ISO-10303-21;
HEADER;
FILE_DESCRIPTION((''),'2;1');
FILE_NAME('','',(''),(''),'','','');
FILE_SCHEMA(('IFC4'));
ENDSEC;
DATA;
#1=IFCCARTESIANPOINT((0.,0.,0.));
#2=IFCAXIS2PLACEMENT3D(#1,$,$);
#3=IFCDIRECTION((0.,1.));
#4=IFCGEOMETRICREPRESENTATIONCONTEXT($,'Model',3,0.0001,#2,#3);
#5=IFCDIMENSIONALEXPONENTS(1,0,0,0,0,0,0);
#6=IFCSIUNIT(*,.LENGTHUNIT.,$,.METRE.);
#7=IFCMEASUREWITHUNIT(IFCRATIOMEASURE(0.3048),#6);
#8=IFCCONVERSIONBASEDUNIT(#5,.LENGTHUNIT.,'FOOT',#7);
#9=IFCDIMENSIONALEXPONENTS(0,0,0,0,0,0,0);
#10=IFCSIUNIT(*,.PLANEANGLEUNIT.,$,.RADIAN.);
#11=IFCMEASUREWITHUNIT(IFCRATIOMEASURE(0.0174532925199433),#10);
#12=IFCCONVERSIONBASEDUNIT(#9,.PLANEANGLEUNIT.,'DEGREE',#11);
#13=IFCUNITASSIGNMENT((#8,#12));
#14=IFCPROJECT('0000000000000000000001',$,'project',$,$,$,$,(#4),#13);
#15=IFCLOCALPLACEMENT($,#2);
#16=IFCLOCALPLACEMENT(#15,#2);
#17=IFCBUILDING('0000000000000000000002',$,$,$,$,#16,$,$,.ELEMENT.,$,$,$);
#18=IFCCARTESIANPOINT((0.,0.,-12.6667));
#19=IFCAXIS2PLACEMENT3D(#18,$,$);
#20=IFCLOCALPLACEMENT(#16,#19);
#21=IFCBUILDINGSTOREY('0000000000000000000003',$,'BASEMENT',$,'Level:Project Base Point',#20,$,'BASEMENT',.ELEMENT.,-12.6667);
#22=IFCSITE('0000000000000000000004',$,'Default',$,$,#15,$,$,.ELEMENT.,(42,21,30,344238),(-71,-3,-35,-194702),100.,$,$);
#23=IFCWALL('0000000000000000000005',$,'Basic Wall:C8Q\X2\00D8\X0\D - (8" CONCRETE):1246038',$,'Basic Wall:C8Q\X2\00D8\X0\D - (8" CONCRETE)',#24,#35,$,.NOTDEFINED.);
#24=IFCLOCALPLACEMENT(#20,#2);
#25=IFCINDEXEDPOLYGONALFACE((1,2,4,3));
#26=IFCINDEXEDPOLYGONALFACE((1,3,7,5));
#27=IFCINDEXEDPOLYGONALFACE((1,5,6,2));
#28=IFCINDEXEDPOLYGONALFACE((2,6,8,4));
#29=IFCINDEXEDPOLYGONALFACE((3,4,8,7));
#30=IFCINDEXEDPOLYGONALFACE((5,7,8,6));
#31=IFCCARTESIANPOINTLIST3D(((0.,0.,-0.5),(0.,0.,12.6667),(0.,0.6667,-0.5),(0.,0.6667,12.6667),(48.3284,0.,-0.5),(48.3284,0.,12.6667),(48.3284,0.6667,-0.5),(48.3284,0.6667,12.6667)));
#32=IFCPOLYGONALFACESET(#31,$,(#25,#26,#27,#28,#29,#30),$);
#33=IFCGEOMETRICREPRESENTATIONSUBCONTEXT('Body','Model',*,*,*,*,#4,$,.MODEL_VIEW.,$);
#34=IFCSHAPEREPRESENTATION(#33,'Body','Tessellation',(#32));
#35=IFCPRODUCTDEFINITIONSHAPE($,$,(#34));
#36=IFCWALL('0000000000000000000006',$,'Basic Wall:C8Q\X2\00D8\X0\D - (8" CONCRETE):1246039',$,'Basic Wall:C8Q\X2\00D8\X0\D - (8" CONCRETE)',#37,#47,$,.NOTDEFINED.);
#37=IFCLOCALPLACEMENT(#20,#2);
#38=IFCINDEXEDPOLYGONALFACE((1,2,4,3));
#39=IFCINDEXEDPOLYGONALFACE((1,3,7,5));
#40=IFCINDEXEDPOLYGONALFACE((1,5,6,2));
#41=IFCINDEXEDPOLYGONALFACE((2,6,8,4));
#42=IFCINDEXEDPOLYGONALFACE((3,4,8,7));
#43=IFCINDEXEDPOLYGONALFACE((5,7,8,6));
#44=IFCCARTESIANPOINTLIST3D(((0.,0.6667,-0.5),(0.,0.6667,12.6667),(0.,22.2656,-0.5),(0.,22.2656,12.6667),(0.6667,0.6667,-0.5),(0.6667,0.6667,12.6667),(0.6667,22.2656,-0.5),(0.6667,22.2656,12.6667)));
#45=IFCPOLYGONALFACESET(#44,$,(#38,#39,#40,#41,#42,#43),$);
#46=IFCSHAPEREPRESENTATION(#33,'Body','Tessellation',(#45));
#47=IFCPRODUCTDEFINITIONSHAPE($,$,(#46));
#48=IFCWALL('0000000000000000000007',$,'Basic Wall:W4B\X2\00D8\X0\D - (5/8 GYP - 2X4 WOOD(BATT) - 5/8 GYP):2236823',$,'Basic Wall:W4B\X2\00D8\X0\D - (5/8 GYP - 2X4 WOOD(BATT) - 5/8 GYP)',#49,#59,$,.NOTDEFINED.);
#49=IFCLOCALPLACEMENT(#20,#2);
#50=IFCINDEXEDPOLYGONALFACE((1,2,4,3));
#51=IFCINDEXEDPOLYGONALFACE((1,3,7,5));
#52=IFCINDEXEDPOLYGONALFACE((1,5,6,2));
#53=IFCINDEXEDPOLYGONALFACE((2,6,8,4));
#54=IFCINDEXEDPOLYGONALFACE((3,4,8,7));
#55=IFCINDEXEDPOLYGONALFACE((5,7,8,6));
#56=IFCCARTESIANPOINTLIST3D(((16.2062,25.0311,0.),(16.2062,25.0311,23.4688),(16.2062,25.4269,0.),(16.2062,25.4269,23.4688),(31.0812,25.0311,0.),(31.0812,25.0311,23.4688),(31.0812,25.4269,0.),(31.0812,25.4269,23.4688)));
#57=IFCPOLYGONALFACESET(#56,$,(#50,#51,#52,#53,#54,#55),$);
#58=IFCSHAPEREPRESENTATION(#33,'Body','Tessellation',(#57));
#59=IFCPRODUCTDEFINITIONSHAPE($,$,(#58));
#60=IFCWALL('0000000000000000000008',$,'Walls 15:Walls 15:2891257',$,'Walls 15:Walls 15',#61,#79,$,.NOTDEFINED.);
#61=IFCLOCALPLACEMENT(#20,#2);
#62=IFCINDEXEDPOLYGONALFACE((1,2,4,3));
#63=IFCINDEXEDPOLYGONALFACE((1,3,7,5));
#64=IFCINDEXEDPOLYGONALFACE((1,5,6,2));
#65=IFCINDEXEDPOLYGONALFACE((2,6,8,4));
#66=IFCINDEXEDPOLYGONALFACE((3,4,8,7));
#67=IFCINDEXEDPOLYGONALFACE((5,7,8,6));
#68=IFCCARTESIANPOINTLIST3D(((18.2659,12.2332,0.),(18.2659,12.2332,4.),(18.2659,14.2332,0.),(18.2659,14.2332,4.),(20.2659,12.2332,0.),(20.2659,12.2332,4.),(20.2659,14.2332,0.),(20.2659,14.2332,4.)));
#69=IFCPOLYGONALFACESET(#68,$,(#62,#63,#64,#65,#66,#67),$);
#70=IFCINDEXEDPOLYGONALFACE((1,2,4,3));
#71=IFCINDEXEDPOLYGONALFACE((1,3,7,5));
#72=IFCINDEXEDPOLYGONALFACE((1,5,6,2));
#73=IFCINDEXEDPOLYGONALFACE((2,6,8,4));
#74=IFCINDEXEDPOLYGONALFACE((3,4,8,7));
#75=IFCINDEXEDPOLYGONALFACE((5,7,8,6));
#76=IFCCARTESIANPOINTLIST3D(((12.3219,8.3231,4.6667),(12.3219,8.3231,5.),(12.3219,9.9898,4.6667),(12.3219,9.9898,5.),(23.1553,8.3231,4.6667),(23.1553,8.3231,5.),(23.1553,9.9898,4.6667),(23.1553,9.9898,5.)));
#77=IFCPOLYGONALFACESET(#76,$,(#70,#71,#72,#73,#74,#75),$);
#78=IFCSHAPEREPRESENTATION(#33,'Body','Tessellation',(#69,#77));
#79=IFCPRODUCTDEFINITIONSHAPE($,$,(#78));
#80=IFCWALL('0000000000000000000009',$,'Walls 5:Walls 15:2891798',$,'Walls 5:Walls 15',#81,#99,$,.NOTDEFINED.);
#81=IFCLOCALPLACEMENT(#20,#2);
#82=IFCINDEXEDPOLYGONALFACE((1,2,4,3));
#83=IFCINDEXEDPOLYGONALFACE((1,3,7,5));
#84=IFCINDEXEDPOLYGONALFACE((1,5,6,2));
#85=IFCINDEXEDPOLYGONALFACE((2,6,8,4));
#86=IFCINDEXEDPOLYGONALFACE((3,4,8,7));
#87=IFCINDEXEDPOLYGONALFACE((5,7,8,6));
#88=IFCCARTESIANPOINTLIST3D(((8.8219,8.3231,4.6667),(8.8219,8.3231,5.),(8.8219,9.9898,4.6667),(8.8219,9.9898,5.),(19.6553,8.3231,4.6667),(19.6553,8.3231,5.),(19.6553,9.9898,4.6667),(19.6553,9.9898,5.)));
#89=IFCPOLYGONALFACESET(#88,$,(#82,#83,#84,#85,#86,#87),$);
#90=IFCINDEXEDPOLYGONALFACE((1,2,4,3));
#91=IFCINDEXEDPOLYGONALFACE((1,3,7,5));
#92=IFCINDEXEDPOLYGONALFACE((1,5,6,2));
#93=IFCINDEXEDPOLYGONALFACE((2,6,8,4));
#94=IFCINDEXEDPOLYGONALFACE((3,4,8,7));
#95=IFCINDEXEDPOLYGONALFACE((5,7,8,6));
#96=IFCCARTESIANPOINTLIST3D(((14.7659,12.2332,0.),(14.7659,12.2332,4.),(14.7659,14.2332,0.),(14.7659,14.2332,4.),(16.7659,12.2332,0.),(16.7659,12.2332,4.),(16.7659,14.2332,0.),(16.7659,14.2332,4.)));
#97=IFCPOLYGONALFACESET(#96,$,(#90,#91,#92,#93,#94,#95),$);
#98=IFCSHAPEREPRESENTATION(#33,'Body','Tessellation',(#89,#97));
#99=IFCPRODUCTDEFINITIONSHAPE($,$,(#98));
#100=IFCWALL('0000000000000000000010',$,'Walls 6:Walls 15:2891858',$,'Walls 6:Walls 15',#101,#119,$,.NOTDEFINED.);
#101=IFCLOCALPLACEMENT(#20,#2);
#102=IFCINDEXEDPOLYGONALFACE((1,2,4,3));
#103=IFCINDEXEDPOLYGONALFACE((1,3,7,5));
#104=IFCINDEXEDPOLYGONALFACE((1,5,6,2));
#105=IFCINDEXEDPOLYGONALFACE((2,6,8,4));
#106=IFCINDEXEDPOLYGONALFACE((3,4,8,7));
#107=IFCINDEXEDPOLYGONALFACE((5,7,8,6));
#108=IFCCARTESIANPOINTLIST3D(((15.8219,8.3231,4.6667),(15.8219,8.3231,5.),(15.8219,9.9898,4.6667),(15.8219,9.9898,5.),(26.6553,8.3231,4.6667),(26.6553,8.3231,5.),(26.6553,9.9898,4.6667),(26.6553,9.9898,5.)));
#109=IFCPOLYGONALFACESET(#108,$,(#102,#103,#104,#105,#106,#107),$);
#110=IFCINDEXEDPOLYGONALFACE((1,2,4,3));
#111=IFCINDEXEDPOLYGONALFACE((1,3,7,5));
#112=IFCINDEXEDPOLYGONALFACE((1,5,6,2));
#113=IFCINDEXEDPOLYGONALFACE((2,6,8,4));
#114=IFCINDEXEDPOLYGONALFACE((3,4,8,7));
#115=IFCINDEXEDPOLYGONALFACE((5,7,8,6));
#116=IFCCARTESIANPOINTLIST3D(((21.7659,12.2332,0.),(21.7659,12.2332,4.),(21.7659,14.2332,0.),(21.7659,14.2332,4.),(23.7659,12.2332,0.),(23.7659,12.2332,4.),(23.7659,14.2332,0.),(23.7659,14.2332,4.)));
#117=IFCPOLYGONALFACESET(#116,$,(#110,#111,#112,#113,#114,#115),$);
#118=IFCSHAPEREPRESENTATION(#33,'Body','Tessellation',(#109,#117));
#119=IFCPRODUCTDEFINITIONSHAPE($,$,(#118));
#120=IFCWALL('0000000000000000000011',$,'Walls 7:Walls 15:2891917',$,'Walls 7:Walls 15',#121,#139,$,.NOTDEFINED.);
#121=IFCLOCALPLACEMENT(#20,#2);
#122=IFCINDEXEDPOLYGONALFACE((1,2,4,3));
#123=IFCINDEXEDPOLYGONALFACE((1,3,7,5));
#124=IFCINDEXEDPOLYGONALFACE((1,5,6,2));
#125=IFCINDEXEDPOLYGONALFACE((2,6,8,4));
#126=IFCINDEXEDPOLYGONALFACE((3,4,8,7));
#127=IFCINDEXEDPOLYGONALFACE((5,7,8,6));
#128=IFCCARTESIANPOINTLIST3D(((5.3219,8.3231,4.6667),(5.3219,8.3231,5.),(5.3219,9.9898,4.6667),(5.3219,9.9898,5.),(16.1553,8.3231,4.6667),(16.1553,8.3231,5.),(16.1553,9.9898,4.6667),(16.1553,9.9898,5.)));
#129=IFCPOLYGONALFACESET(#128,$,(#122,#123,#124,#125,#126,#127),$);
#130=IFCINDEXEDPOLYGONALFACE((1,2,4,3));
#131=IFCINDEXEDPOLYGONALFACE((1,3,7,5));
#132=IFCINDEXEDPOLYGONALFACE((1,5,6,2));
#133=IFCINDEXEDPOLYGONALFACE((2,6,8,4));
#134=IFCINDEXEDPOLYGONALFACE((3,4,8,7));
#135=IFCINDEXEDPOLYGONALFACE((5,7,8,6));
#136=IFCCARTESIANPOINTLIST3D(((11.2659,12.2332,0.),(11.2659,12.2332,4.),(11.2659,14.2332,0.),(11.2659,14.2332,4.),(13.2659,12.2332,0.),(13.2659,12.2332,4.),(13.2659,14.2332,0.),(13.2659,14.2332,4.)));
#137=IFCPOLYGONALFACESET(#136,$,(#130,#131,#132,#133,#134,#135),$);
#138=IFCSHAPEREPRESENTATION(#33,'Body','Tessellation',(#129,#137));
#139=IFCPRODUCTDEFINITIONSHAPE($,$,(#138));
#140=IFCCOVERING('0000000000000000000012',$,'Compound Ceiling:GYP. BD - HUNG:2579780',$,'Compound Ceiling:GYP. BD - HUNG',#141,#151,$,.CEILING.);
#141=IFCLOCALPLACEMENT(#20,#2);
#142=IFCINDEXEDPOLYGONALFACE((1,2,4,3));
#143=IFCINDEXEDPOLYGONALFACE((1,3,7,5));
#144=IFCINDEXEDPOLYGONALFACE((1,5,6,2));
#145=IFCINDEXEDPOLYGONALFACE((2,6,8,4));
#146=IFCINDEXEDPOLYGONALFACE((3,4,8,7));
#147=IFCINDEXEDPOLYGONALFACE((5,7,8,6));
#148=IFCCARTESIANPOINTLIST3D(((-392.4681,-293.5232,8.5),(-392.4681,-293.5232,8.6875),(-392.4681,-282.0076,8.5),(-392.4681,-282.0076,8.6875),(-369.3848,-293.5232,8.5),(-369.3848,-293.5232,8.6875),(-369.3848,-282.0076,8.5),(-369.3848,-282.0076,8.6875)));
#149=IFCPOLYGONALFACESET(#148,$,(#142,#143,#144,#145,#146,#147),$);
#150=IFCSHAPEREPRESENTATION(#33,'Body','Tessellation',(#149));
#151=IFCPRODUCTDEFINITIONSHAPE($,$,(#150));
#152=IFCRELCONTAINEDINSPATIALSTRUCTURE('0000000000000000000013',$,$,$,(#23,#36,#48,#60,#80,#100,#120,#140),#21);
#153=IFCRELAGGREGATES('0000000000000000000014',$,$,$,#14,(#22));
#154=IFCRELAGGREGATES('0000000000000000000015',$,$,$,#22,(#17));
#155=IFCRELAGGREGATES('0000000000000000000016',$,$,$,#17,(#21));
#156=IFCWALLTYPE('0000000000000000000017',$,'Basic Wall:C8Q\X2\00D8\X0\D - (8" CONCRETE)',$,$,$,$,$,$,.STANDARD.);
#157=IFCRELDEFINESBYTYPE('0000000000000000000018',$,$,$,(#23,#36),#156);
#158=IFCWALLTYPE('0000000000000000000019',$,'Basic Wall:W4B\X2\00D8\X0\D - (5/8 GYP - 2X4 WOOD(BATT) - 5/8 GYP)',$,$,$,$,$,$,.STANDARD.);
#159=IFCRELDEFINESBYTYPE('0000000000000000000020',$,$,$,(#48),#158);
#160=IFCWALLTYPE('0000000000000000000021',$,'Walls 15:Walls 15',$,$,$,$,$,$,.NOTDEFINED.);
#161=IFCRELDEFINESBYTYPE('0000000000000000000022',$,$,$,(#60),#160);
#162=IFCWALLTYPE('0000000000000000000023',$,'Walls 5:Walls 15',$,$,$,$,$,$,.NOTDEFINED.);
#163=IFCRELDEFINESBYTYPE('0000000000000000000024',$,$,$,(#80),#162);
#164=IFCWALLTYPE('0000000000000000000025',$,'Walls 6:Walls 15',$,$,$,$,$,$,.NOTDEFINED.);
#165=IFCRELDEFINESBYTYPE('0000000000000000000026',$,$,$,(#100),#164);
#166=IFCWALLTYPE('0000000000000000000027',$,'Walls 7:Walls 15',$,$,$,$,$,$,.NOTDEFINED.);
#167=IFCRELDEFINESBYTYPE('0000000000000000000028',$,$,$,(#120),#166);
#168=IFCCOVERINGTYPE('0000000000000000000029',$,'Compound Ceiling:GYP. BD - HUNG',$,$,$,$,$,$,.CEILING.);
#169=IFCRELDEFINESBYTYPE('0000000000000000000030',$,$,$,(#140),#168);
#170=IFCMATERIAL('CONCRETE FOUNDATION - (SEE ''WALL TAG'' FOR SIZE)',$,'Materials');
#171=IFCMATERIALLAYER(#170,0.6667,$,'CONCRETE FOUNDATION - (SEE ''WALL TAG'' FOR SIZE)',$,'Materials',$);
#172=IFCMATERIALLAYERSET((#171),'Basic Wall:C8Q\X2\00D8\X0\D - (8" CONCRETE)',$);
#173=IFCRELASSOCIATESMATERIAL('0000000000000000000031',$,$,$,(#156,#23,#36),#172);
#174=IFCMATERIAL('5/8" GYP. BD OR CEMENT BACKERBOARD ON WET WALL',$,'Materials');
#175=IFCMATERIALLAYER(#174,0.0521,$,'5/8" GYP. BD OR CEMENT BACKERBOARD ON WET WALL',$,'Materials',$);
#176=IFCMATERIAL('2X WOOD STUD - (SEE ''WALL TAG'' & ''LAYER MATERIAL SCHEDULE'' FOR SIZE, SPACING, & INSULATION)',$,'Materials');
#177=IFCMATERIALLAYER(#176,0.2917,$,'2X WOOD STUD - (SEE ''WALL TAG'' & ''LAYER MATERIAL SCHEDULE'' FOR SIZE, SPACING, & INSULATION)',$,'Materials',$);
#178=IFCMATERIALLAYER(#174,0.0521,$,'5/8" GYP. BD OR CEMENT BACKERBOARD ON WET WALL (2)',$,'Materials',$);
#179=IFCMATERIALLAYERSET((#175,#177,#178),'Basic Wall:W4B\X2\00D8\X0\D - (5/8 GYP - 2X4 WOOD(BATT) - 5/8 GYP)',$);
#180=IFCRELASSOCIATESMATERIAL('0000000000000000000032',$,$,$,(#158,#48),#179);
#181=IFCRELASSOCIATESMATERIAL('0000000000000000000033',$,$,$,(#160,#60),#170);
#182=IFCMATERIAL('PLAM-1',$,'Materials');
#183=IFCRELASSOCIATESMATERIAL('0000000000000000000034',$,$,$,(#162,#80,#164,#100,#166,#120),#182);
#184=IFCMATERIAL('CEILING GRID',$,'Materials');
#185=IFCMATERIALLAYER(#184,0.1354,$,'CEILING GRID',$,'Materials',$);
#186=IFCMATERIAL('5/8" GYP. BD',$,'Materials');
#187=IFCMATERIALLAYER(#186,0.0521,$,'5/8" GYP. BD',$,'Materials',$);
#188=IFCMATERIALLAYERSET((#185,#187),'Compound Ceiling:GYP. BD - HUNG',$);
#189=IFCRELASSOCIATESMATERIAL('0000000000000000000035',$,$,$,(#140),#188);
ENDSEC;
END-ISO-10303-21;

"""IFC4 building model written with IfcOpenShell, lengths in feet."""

from ifc_helpers import new_model, entity, si_unit, converted_unit, direction, frame, frame_2d, origin, origin_2d_with_axis, place, context, subcontext, project, spatial, rectangle, extrude, material, layer, layer_set, layer_usage, type_object, element, save


model = new_model("IFC4")

# Units and contexts
model_context = context("Model", 3, precision=0.0001, world=origin(), true_north=direction((0.0, 1.0)))
body_context = subcontext(model_context, "Body", "Model", "MODEL_VIEW")
ifc_project = project(units=[converted_unit("LENGTHUNIT", "FOOT", entity("IfcRatioMeasure", 0.3048), si_unit("LENGTHUNIT", "METRE"), dimensions=[1, 0, 0, 0, 0, 0, 0]), converted_unit("PLANEANGLEUNIT", "DEGREE", entity("IfcRatioMeasure", 0.0174532925199433), si_unit("PLANEANGLEUNIT", "RADIAN"), dimensions=[0, 0, 0, 0, 0, 0, 0])], contexts=[model_context])

# Site, building, storey
site_placement = place(None, origin())
site = spatial("IfcSite", under=ifc_project, at=site_placement, Name="Default", CompositionType="ELEMENT", RefLatitude=(42, 21, 30, 344238), RefLongitude=(-71, -3, -35, -194702), RefElevation=100.0)
building_placement = place(site_placement, origin())
building = spatial("IfcBuilding", under=site, at=building_placement, CompositionType="ELEMENT")
storey_placement = place(building_placement, frame((0.0, 0.0, -12.6667)))
storey = spatial("IfcBuildingStorey", under=building, at=storey_placement, Name="BASEMENT", ObjectType="Level:Project Base Point", LongName="BASEMENT", CompositionType="ELEMENT", Elevation=-12.6667)

# Shared definitions
ifc_material_1 = material(Name="5/8\" GYP. BD", Category="Materials")

# Walls
ifc_material_2 = material(Name="CONCRETE FOUNDATION - (SEE 'WALL TAG' FOR SIZE)", Category="Materials")
ifc_layer_1 = layer(ifc_material_2, 0.6667, Name="CONCRETE FOUNDATION - (SEE 'WALL TAG' FOR SIZE)", Category="Materials")
ifc_layer_set_1 = layer_set([ifc_layer_1], Name="Basic Wall:C8QØD - (8\" CONCRETE)")
ifc_layer_usage_1 = layer_usage(ifc_layer_set_1, "AXIS2", "POSITIVE", -0.3333)
wall_type_1 = type_object("IfcWallType", Name="Basic Wall:C8QØD - (8\" CONCRETE)", PredefinedType="STANDARD", material=ifc_layer_set_1)
wall_1_placement = place(storey_placement, frame((0.0, 0.3333, -0.5)))
element("IfcWall", 1, at=wall_1_placement, inside=storey, type_object=wall_type_1, material=ifc_layer_usage_1, Name="Basic Wall:C8QØD - (8\" CONCRETE):1246038", ObjectType="Basic Wall:C8QØD - (8\" CONCRETE)", PredefinedType="NOTDEFINED", context=body_context, shape_type="SweptSolid", body=[
    extrude(rectangle(XDim=48.3284, YDim=0.6667, at=frame_2d((24.1642, 0.0), x_axis=(-1.0, 0.0))), origin(), (0.0, 0.0, 1.0), 13.1667),
])
ifc_layer_usage_2 = layer_usage(ifc_layer_set_1, "AXIS2", "POSITIVE", -0.3333)
wall_2_placement = place(storey_placement, frame((0.3333, 22.2656, -0.5), z_axis=(0.0, 0.0, 1.0), x_axis=(0.0, -1.0, 0.0)))
element("IfcWall", 2, at=wall_2_placement, inside=storey, type_object=wall_type_1, material=ifc_layer_usage_2, Name="Basic Wall:C8QØD - (8\" CONCRETE):1246039", ObjectType="Basic Wall:C8QØD - (8\" CONCRETE)", PredefinedType="NOTDEFINED", context=body_context, shape_type="SweptSolid", body=[
    extrude(rectangle(XDim=21.599, YDim=0.6667, at=frame_2d((10.7995, 0.0), x_axis=(-1.0, 0.0))), origin(), (0.0, 0.0, 1.0), 13.1667),
])
ifc_material_3 = material(Name="5/8\" GYP. BD OR CEMENT BACKERBOARD ON WET WALL", Category="Materials")
ifc_layer_2 = layer(ifc_material_3, 0.0521, Name="5/8\" GYP. BD OR CEMENT BACKERBOARD ON WET WALL", Category="Materials")
ifc_material_4 = material(Name="2X WOOD STUD - (SEE 'WALL TAG' & 'LAYER MATERIAL SCHEDULE' FOR SIZE, SPACING, & INSULATION)", Category="Materials")
ifc_layer_3 = layer(ifc_material_4, 0.2917, Name="2X WOOD STUD - (SEE 'WALL TAG' & 'LAYER MATERIAL SCHEDULE' FOR SIZE, SPACING, & INSULATION)", Category="Materials")
ifc_layer_4 = layer(ifc_material_3, 0.0521, Name="5/8\" GYP. BD OR CEMENT BACKERBOARD ON WET WALL (2)", Category="Materials")
ifc_layer_set_2 = layer_set([ifc_layer_2, ifc_layer_3, ifc_layer_4], Name="Basic Wall:W4BØD - (5/8 GYP - 2X4 WOOD(BATT) - 5/8 GYP)")
ifc_layer_usage_3 = layer_usage(ifc_layer_set_2, "AXIS2", "NEGATIVE", 0.1979)
wall_type_2 = type_object("IfcWallType", Name="Basic Wall:W4BØD - (5/8 GYP - 2X4 WOOD(BATT) - 5/8 GYP)", PredefinedType="STANDARD", material=ifc_layer_set_2)
wall_3_placement = place(storey_placement, frame((16.2062, 25.229, 0.0)))
element("IfcWall", 3, at=wall_3_placement, inside=storey, type_object=wall_type_2, material=ifc_layer_usage_3, Name="Basic Wall:W4BØD - (5/8 GYP - 2X4 WOOD(BATT) - 5/8 GYP):2236823", ObjectType="Basic Wall:W4BØD - (5/8 GYP - 2X4 WOOD(BATT) - 5/8 GYP)", PredefinedType="NOTDEFINED", context=body_context, shape_type="SweptSolid", body=[
    extrude(rectangle(XDim=14.875, YDim=0.3958, at=frame_2d((7.4375, 0.0), x_axis=(-1.0, 0.0))), origin(), (0.0, 0.0, 1.0), 23.4688),
])
wall_type_3 = type_object("IfcWallType", Name="Walls 15:Walls 15", PredefinedType="NOTDEFINED", material=ifc_material_2)
wall_4_placement = place(storey_placement, frame((12.3219, 8.3231, 0.0)))
element("IfcWall", 4, at=wall_4_placement, inside=storey, type_object=wall_type_3, material=ifc_material_2, Name="Walls 15:Walls 15:2891257", ObjectType="Walls 15:Walls 15", PredefinedType="NOTDEFINED", context=body_context, shape_type="SweptSolid", body=[
    extrude(rectangle(XDim=2.0, YDim=2.0, at=origin_2d_with_axis()), frame((6.944, 4.9101, 0.0), z_axis=(0.0, 0.0, 1.0), x_axis=(-1.0, 0.0, 0.0)), (0.0, 0.0, 1.0), 4.0),
    extrude(rectangle(XDim=10.8333, YDim=1.6667, at=frame_2d((0.0, 0.0), x_axis=(1.0, 0.0))), frame((5.4167, 0.8333, 4.6667), z_axis=(0.0, 0.0, 1.0), x_axis=(-1.0, 0.0, 0.0)), (0.0, 0.0, 1.0), 0.3333),
])
ifc_material_5 = material(Name="PLAM-1", Category="Materials")
wall_type_4 = type_object("IfcWallType", Name="Walls 5:Walls 15", PredefinedType="NOTDEFINED", material=ifc_material_5)
wall_5_placement = place(storey_placement, frame((8.8219, 8.3231, 0.0)))
element("IfcWall", 5, at=wall_5_placement, inside=storey, type_object=wall_type_4, material=ifc_material_5, Name="Walls 5:Walls 15:2891798", ObjectType="Walls 5:Walls 15", PredefinedType="NOTDEFINED", context=body_context, shape_type="SweptSolid", body=[
    extrude(rectangle(XDim=10.8333, YDim=1.6667, at=frame_2d((0.0, 0.0), x_axis=(1.0, 0.0))), frame((5.4167, 0.8333, 4.6667), z_axis=(0.0, 0.0, 1.0), x_axis=(-1.0, 0.0, 0.0)), (0.0, 0.0, 1.0), 0.3333),
    extrude(rectangle(XDim=2.0, YDim=2.0, at=origin_2d_with_axis()), frame((6.944, 4.9101, 0.0), z_axis=(0.0, 0.0, 1.0), x_axis=(-1.0, 0.0, 0.0)), (0.0, 0.0, 1.0), 4.0),
])
wall_type_5 = type_object("IfcWallType", Name="Walls 6:Walls 15", PredefinedType="NOTDEFINED", material=ifc_material_5)
wall_6_placement = place(storey_placement, frame((15.8219, 8.3231, 0.0)))
element("IfcWall", 6, at=wall_6_placement, inside=storey, type_object=wall_type_5, material=ifc_material_5, Name="Walls 6:Walls 15:2891858", ObjectType="Walls 6:Walls 15", PredefinedType="NOTDEFINED", context=body_context, shape_type="SweptSolid", body=[
    extrude(rectangle(XDim=10.8333, YDim=1.6667, at=frame_2d((0.0, 0.0), x_axis=(1.0, 0.0))), frame((5.4167, 0.8333, 4.6667), z_axis=(0.0, 0.0, 1.0), x_axis=(-1.0, 0.0, 0.0)), (0.0, 0.0, 1.0), 0.3333),
    extrude(rectangle(XDim=2.0, YDim=2.0, at=origin_2d_with_axis()), frame((6.944, 4.9101, 0.0), z_axis=(0.0, 0.0, 1.0), x_axis=(-1.0, 0.0, 0.0)), (0.0, 0.0, 1.0), 4.0),
])
wall_type_6 = type_object("IfcWallType", Name="Walls 7:Walls 15", PredefinedType="NOTDEFINED", material=ifc_material_5)
wall_7_placement = place(storey_placement, frame((5.3219, 8.3231, 0.0)))
element("IfcWall", 7, at=wall_7_placement, inside=storey, type_object=wall_type_6, material=ifc_material_5, Name="Walls 7:Walls 15:2891917", ObjectType="Walls 7:Walls 15", PredefinedType="NOTDEFINED", context=body_context, shape_type="SweptSolid", body=[
    extrude(rectangle(XDim=10.8333, YDim=1.6667, at=frame_2d((0.0, 0.0), x_axis=(1.0, 0.0))), frame((5.4167, 0.8333, 4.6667), z_axis=(0.0, 0.0, 1.0), x_axis=(-1.0, 0.0, 0.0)), (0.0, 0.0, 1.0), 0.3333),
    extrude(rectangle(XDim=2.0, YDim=2.0, at=origin_2d_with_axis()), frame((6.944, 4.9101, 0.0), z_axis=(0.0, 0.0, 1.0), x_axis=(-1.0, 0.0, 0.0)), (0.0, 0.0, 1.0), 4.0),
])

# Covering
ifc_material_6 = material(Name="CEILING GRID", Category="Materials")
ifc_layer_5 = layer(ifc_material_6, 0.1354, Name="CEILING GRID", Category="Materials")
ifc_layer_6 = layer(ifc_material_1, 0.0521, Name="5/8\" GYP. BD", Category="Materials")
ifc_layer_set_3 = layer_set([ifc_layer_5, ifc_layer_6], Name="Compound Ceiling:GYP. BD - HUNG")
ifc_layer_usage_4 = layer_usage(ifc_layer_set_3, "AXIS3", "POSITIVE", 0.0)
covering_type_1 = type_object("IfcCoveringType", Name="Compound Ceiling:GYP. BD - HUNG", PredefinedType="CEILING")
covering_1_placement = place(storey_placement, frame((-392.4681, -293.5232, 8.5)))
element("IfcCovering", 8, at=covering_1_placement, inside=storey, type_object=covering_type_1, material=ifc_layer_usage_4, Name="Compound Ceiling:GYP. BD - HUNG:2579780", ObjectType="Compound Ceiling:GYP. BD - HUNG", PredefinedType="CEILING", context=body_context, shape_type="SweptSolid", body=[
    extrude(rectangle(XDim=23.0833, YDim=11.5156, at=frame_2d((0.0, 0.0), x_axis=(1.0, 0.0))), frame((11.5417, 5.7578, 0.0), z_axis=(0.0, 0.0, 1.0), x_axis=(-1.0, 0.0, 0.0)), (0.0, 0.0, 1.0), 0.1875),
])

save(model, "model.ifc")
